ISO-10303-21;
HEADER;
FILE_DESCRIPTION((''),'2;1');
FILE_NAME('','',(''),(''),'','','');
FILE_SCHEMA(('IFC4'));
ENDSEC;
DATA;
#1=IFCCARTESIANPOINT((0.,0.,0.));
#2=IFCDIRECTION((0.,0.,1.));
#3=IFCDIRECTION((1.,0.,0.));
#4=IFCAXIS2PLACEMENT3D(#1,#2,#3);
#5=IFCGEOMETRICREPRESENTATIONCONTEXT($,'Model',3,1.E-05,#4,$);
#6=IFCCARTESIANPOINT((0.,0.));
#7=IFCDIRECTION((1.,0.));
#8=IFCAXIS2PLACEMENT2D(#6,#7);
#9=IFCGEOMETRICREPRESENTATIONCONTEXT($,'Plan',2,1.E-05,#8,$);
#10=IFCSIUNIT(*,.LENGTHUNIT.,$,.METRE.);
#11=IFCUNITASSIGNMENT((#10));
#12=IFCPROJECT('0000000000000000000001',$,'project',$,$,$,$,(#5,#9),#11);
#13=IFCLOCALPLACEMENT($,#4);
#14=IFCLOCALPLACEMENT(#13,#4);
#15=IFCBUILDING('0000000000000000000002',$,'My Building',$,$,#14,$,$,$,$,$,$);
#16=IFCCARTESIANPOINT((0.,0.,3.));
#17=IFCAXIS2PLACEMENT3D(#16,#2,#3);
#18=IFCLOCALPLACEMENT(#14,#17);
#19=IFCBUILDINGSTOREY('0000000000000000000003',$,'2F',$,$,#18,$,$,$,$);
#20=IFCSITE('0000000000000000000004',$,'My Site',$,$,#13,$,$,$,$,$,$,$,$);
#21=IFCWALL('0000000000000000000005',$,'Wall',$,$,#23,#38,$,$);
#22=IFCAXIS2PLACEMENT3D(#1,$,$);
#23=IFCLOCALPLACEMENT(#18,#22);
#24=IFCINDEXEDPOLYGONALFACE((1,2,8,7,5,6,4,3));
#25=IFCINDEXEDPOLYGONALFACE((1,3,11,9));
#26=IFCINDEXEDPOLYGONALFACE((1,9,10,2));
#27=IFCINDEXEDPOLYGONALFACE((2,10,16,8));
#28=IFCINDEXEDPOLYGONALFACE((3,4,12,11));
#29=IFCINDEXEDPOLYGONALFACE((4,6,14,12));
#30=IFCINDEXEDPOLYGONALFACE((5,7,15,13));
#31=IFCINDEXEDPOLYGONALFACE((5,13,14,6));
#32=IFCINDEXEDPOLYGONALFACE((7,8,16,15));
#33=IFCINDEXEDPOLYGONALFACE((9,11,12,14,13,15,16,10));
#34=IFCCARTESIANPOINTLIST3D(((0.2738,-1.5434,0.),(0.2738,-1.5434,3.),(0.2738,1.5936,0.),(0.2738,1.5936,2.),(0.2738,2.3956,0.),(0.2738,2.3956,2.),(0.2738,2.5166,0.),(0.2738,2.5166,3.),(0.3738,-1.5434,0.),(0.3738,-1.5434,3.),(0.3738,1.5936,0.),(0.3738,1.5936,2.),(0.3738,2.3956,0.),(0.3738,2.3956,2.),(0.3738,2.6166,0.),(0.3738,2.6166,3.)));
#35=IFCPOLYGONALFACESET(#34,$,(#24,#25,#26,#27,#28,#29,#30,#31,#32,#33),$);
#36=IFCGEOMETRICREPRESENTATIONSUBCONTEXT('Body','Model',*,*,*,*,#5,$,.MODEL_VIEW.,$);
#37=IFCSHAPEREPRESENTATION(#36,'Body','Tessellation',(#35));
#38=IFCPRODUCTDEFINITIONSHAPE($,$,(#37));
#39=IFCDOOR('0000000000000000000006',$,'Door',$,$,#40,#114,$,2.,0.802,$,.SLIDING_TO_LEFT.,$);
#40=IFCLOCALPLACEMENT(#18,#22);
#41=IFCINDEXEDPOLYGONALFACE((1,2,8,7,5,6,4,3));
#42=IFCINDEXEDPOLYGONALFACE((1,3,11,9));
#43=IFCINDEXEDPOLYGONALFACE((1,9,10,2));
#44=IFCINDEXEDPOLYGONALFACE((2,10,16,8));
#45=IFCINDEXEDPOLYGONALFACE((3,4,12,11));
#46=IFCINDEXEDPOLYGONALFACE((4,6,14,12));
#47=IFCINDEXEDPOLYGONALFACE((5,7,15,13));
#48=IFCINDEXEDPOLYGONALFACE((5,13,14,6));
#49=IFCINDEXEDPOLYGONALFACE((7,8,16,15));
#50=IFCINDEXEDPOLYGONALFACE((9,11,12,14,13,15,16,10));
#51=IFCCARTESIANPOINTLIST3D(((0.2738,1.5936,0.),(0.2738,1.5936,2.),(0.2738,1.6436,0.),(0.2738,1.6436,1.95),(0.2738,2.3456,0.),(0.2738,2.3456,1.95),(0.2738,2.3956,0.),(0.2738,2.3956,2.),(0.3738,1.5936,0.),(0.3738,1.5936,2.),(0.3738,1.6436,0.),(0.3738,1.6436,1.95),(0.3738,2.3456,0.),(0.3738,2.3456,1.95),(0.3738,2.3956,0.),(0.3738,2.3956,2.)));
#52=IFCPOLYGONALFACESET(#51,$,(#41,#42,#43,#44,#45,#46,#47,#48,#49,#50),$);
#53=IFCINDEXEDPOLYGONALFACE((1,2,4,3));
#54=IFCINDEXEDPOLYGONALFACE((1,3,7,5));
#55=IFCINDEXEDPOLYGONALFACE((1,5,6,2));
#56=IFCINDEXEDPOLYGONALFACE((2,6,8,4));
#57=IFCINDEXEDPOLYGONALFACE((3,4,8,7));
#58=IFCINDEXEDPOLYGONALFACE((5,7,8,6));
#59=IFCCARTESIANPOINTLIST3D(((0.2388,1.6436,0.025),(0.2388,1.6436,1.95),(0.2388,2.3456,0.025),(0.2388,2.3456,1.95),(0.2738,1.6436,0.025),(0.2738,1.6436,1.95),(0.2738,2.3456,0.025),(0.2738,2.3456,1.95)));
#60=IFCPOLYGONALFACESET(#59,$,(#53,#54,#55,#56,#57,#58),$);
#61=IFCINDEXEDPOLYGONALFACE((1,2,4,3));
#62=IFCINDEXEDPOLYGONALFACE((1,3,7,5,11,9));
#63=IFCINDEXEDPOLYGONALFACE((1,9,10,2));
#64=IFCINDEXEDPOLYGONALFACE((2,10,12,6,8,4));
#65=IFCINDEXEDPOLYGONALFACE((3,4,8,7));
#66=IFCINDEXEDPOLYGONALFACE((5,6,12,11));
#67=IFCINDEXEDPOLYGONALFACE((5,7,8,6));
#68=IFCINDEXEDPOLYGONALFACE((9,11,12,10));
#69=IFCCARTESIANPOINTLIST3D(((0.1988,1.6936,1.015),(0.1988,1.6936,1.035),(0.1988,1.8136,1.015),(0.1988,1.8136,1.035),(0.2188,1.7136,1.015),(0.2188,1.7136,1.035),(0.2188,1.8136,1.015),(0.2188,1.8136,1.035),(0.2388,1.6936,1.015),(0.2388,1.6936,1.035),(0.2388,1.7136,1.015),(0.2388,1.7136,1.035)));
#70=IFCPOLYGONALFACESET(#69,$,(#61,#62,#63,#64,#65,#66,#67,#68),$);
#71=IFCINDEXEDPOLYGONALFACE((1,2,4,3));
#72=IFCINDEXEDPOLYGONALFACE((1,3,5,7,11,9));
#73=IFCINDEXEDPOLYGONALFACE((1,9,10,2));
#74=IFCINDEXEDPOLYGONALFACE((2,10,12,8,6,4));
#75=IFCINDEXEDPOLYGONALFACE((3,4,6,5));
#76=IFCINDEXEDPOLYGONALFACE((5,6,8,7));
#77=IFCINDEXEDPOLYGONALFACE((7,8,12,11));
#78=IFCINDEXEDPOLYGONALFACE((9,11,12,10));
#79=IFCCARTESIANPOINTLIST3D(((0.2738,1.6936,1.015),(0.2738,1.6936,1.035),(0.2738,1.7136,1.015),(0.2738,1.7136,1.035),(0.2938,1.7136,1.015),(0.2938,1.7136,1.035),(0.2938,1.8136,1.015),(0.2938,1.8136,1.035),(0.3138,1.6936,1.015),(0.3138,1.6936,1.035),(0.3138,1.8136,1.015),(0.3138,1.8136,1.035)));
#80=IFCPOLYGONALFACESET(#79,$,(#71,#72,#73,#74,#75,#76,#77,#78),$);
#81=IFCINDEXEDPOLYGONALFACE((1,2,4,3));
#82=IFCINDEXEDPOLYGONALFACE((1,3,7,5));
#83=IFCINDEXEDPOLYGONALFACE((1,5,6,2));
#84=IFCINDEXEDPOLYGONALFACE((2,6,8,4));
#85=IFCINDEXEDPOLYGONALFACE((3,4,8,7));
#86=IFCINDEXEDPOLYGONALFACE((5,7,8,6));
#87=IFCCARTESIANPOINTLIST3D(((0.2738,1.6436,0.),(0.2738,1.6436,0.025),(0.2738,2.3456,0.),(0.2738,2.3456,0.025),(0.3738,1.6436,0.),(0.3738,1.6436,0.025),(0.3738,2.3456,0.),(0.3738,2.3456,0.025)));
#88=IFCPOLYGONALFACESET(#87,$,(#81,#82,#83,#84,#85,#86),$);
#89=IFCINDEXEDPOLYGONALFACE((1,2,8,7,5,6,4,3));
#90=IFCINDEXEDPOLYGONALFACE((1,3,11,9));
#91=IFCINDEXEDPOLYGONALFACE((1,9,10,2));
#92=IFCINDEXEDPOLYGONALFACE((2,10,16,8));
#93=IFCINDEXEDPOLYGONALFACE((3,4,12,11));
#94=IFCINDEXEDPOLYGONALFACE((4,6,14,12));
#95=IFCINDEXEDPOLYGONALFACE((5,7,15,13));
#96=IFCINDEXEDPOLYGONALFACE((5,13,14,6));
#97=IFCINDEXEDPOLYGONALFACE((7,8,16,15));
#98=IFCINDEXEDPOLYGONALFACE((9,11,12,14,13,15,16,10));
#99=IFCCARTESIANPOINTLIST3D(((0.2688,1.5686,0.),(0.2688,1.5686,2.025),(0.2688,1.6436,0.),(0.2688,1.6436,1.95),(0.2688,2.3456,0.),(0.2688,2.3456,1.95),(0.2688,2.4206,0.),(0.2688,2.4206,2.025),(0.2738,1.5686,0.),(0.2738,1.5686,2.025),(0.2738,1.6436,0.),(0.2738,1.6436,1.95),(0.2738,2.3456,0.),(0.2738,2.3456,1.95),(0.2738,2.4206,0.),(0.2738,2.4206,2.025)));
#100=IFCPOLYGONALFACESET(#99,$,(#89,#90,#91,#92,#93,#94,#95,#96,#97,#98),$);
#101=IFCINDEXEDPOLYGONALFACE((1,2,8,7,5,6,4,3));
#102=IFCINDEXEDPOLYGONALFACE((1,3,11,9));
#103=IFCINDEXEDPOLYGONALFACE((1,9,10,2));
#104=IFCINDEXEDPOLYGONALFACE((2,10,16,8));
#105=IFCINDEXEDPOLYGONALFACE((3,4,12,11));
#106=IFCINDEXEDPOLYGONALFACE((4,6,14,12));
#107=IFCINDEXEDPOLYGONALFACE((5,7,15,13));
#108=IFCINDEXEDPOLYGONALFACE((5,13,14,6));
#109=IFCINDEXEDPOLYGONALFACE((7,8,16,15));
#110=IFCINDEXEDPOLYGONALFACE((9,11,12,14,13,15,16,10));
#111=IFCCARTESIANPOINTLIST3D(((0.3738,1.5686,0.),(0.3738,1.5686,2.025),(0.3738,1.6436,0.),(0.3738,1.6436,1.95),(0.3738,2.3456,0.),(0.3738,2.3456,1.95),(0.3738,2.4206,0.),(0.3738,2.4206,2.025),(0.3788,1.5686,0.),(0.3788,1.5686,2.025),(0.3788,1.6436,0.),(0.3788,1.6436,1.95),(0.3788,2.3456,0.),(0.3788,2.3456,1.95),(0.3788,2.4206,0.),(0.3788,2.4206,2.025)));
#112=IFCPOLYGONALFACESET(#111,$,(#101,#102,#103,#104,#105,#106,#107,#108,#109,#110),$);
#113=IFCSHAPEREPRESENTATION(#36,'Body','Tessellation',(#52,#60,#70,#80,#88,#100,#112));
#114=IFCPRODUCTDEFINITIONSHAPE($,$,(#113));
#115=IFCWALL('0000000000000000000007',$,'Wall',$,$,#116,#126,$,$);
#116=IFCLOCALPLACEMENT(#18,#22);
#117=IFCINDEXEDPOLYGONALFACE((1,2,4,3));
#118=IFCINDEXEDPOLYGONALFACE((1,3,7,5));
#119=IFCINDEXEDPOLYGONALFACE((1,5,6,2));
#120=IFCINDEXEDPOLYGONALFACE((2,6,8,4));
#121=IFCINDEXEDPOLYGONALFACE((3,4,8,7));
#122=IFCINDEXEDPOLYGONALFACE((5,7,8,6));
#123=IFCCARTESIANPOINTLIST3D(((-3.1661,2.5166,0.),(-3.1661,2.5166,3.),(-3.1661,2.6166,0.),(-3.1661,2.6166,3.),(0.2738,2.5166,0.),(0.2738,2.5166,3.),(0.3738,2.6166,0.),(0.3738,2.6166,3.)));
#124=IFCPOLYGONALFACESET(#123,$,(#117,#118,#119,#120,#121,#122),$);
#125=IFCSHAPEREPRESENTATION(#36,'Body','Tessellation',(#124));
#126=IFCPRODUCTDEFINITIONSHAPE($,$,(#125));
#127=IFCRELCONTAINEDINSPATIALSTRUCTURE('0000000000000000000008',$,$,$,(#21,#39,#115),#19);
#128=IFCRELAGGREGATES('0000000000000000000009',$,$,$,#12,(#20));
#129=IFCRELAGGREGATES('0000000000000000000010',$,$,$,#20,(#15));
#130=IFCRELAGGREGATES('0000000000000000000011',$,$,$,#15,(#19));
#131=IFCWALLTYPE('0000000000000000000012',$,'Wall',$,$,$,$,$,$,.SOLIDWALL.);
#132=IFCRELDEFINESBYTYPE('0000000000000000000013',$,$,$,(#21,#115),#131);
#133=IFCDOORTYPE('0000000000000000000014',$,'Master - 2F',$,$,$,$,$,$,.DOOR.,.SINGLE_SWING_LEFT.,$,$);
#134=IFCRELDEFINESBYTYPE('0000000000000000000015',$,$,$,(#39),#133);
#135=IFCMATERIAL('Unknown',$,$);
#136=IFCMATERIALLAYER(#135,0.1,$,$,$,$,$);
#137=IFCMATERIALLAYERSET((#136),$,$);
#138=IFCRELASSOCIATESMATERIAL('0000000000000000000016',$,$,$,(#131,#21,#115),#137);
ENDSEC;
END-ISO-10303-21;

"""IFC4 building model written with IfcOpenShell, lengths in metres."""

from ifc_helpers import new_model, entity, si_unit, frame, origin_with_axes, origin_2d_with_axis, place, context, subcontext, project, spatial, line, indexed_curve, outline, extrude, shape, source, transform, mapped, material, layer, layer_set, layer_usage, type_object, type_shapes, element, fill, save


model = new_model("IFC4")

# Units and contexts
model_context = context("Model", 3, precision=1e-05, world=origin_with_axes())
plan_context = context("Plan", 2, precision=1e-05, world=origin_2d_with_axis())
body_context_1 = subcontext(model_context, "Body", "Model", "MODEL_VIEW")
body_context_2 = subcontext(plan_context, "Body", "Plan", "PLAN_VIEW")
ifc_project = project(units=[si_unit("LENGTHUNIT", "METRE")], contexts=[model_context, plan_context])

# Site, building, storey
site_placement = place(None, origin_with_axes())
site = spatial("IfcSite", under=ifc_project, at=site_placement, Name="My Site")
building_placement = place(site_placement, origin_with_axes())
building = spatial("IfcBuilding", under=site, at=building_placement, Name="My Building")
storey_placement = place(building_placement, frame((0.0, 0.0, 3.0), z_axis=(0.0, 0.0, 1.0), x_axis=(1.0, 0.0, 0.0)))
storey = spatial("IfcBuildingStorey", under=building, at=storey_placement, Name="2F")

# Shared definitions
ifc_material = material(Name="Unknown")

# Shared definitions
ifc_layer_1 = layer(ifc_material, 0.1)
ifc_layer_set_1 = layer_set([ifc_layer_1])
wall_type = type_object("IfcWallType", Name="Wall", PredefinedType="SOLIDWALL", material=ifc_layer_set_1)

# Wall, opening, door
ifc_layer_usage_1 = layer_usage(ifc_layer_set_1, "AXIS2", "POSITIVE", 0.0)
wall_1_placement = place(storey_placement, frame((0.3738, -1.5434, 0.0), z_axis=(0.0, 0.0, 1.0), x_axis=(0.0, 1.0, 0.0)))
wall_1 = element("IfcWall", 1, at=wall_1_placement, inside=storey, type_object=wall_type, material=ifc_layer_usage_1, Name="Wall", context=body_context_1, shape_type="SweptSolid", body=[
    extrude(outline(indexed_curve([(0.0, 0.0), (0.0, 0.1), (4.06, 0.1), (4.16, 0.0)], segments=[line(1, 2, 3, 4, 1)])), origin_with_axes(), (0.0, 0.0, 1.0), 3.0),
])
shared_shape_1 = source(origin_with_axes(), body_context_1, "Body", "SweptSolid", [
    extrude(outline(indexed_curve([(0.0, 0.0), (0.802, 0.0), (0.802, 2.0), (0.0, 2.0)], segments=[line(1, 2, 3, 4, 1)])), frame((0.0, -0.6, 0.0), z_axis=(0.0, -1.0, 0.0), x_axis=(1.0, 0.0, 0.0)), (0.0, 0.0, -1.0), 1.2),
])
opening_1_placement = place(wall_1_placement, frame((3.9391, 0.1, 0.0), z_axis=(0.0, 0.0, 1.0), x_axis=(-1.0, 0.0, 0.0)))
opening_1 = element("IfcOpeningElement", 2, at=opening_1_placement, cuts=wall_1, PredefinedType="OPENING", context=body_context_1, shape_type="MappedRepresentation", body=[
    mapped(shared_shape_1, transform((0.0, 0.0, 0.0), x_axis=(1.0, 0.0, 0.0), y_axis=(0.0, 1.0, 0.0), z_axis=(0.0, 0.0, 1.0), scale=1.0)),
])
door_type_1 = type_object("IfcDoorType", Name="Master - 2F", OperationType="SINGLE_SWING_LEFT", PredefinedType="DOOR")
shared_shape_2 = source(origin_with_axes(), body_context_1, "Body", "SweptSolid", [
    extrude(outline(indexed_curve([(0.0, 0.0), (0.0, 2.0), (0.802, 2.0), (0.802, 0.0), (0.752, 0.0), (0.752, 1.95), (0.05, 1.95), (0.05, 0.0)], segments=[line(1, 2, 3, 4, 5, 6, 7, 8, 1)])), frame((0.0, 0.0, 0.0), z_axis=(0.0, -1.0, 0.0), x_axis=(1.0, 0.0, 0.0)), (0.0, 0.0, -1.0), 0.1),
    extrude(outline(indexed_curve([(0.0, 0.0), (0.702, 0.0), (0.702, 0.035), (0.0, 0.035)], segments=[line(1, 2, 3, 4, 1)])), frame((0.05, -0.035, 0.025), z_axis=(0.0, 0.0, 1.0), x_axis=(1.0, 0.0, 0.0)), (0.0, 0.0, 1.0), 1.925),
    extrude(outline(indexed_curve([(0.0, 0.0), (0.0, -0.04), (-0.12, -0.04), (-0.12, -0.02), (-0.02, -0.02), (-0.02, 0.0)], segments=[line(1, 2, 3, 4, 5, 6, 1)])), frame((0.702, -0.035, 1.015), z_axis=(0.0, 0.0, 1.0), x_axis=(1.0, 0.0, 0.0)), (0.0, 0.0, 1.0), 0.02),
    extrude(outline(indexed_curve([(0.0, 0.0), (0.0, 0.04), (-0.12, 0.04), (-0.12, 0.02), (-0.02, 0.02), (-0.02, 0.0)], segments=[line(1, 2, 3, 4, 5, 6, 1)])), frame((0.702, 0.0, 1.015), z_axis=(0.0, 0.0, 1.0), x_axis=(1.0, 0.0, 0.0)), (0.0, 0.0, 1.0), 0.02),
    extrude(outline(indexed_curve([(0.0, 0.0), (0.702, 0.0), (0.702, 0.1), (0.0, 0.1)], segments=[line(1, 2, 3, 4, 1)])), frame((0.05, 0.0, 0.0), z_axis=(0.0, 0.0, 1.0), x_axis=(1.0, 0.0, 0.0)), (0.0, 0.0, 1.0), 0.025),
    extrude(outline(indexed_curve([(0.0, 0.0), (0.0, 2.025), (0.852, 2.025), (0.852, 0.0), (0.777, 0.0), (0.777, 1.95), (0.075, 1.95), (0.075, 0.0)], segments=[line(1, 2, 3, 4, 5, 6, 7, 8, 1)])), frame((-0.025, -0.005, 0.0), z_axis=(0.0, -1.0, 0.0), x_axis=(1.0, 0.0, 0.0)), (0.0, 0.0, -1.0), 0.005),
    extrude(outline(indexed_curve([(0.0, 0.0), (0.0, 2.025), (0.852, 2.025), (0.852, 0.0), (0.777, 0.0), (0.777, 1.95), (0.075, 1.95), (0.075, 0.0)], segments=[line(1, 2, 3, 4, 5, 6, 7, 8, 1)])), frame((-0.025, 0.1, 0.0), z_axis=(0.0, -1.0, 0.0), x_axis=(1.0, 0.0, 0.0)), (0.0, 0.0, -1.0), 0.005),
])
shared_shape_3 = source(origin_with_axes(), body_context_2, "Body", "Curve2D", [
    entity("IfcIndexedPolyCurve", entity("IfcCartesianPointList2D", [[0.0, 0.0], [0.05, 0.0], [0.05, 0.1], [0.0, 0.1]]), [entity("IfcLineIndex", [1, 2, 3, 4, 1])]),
    entity("IfcIndexedPolyCurve", entity("IfcCartesianPointList2D", [[0.802, 0.0], [0.752, 0.0], [0.752, 0.1], [0.802, 0.1]]), [entity("IfcLineIndex", [1, 2, 3, 4, 1])]),
    entity("IfcIndexedPolyCurve", entity("IfcCartesianPointList2D", [[-0.301, -0.035], [0.401, -0.035], [0.401, 0.0], [-0.301, 0.0]]), [entity("IfcLineIndex", [1, 2, 3, 4, 1])]),
])
type_shapes(door_type_1, [shared_shape_2, shared_shape_3])
door_1_placement = place(opening_1_placement, frame((0.0, 0.0, 0.0), z_axis=(0.0, 0.0, 1.0), x_axis=(1.0, 0.0, 0.0)))
door_1 = element("IfcDoor", 3, at=door_1_placement, inside=storey, type_object=door_type_1, Name="Door", OperationType="SLIDING_TO_LEFT", OverallHeight=2.0, OverallWidth=0.802, shapes=[
    shape(body_context_1, "Body", "MappedRepresentation", [mapped(shared_shape_2, transform((0.0, 0.0, 0.0), x_axis=(1.0, 0.0, 0.0), y_axis=(0.0, 1.0, 0.0), z_axis=(0.0, 0.0, 1.0), scale=1.0))]),
    shape(body_context_2, "Body", "MappedRepresentation", [mapped(shared_shape_3, transform((0.0, 0.0, 0.0), x_axis=(1.0, 0.0, 0.0), y_axis=(0.0, 1.0, 0.0), z_axis=(0.0, 0.0, 1.0), scale=1.0))]),
])
fill(opening_1, door_1)

# Wall
ifc_layer_usage_2 = layer_usage(ifc_layer_set_1, "AXIS2", "POSITIVE", 0.0)
wall_2_placement = place(storey_placement, frame((0.3738, 2.6166, 0.0), z_axis=(0.0, 0.0, 1.0), x_axis=(-1.0, 0.0, 0.0)))
element("IfcWall", 4, at=wall_2_placement, inside=storey, type_object=wall_type, material=ifc_layer_usage_2, Name="Wall", context=body_context_1, shape_type="SweptSolid", body=[
    extrude(outline(indexed_curve([(0.0, 0.0), (0.1, 0.1), (3.54, 0.1), (3.54, 0.0)], segments=[line(1, 2, 3, 4, 1)])), origin_with_axes(), (0.0, 0.0, 1.0), 3.0),
])

save(model, "model.ifc")
